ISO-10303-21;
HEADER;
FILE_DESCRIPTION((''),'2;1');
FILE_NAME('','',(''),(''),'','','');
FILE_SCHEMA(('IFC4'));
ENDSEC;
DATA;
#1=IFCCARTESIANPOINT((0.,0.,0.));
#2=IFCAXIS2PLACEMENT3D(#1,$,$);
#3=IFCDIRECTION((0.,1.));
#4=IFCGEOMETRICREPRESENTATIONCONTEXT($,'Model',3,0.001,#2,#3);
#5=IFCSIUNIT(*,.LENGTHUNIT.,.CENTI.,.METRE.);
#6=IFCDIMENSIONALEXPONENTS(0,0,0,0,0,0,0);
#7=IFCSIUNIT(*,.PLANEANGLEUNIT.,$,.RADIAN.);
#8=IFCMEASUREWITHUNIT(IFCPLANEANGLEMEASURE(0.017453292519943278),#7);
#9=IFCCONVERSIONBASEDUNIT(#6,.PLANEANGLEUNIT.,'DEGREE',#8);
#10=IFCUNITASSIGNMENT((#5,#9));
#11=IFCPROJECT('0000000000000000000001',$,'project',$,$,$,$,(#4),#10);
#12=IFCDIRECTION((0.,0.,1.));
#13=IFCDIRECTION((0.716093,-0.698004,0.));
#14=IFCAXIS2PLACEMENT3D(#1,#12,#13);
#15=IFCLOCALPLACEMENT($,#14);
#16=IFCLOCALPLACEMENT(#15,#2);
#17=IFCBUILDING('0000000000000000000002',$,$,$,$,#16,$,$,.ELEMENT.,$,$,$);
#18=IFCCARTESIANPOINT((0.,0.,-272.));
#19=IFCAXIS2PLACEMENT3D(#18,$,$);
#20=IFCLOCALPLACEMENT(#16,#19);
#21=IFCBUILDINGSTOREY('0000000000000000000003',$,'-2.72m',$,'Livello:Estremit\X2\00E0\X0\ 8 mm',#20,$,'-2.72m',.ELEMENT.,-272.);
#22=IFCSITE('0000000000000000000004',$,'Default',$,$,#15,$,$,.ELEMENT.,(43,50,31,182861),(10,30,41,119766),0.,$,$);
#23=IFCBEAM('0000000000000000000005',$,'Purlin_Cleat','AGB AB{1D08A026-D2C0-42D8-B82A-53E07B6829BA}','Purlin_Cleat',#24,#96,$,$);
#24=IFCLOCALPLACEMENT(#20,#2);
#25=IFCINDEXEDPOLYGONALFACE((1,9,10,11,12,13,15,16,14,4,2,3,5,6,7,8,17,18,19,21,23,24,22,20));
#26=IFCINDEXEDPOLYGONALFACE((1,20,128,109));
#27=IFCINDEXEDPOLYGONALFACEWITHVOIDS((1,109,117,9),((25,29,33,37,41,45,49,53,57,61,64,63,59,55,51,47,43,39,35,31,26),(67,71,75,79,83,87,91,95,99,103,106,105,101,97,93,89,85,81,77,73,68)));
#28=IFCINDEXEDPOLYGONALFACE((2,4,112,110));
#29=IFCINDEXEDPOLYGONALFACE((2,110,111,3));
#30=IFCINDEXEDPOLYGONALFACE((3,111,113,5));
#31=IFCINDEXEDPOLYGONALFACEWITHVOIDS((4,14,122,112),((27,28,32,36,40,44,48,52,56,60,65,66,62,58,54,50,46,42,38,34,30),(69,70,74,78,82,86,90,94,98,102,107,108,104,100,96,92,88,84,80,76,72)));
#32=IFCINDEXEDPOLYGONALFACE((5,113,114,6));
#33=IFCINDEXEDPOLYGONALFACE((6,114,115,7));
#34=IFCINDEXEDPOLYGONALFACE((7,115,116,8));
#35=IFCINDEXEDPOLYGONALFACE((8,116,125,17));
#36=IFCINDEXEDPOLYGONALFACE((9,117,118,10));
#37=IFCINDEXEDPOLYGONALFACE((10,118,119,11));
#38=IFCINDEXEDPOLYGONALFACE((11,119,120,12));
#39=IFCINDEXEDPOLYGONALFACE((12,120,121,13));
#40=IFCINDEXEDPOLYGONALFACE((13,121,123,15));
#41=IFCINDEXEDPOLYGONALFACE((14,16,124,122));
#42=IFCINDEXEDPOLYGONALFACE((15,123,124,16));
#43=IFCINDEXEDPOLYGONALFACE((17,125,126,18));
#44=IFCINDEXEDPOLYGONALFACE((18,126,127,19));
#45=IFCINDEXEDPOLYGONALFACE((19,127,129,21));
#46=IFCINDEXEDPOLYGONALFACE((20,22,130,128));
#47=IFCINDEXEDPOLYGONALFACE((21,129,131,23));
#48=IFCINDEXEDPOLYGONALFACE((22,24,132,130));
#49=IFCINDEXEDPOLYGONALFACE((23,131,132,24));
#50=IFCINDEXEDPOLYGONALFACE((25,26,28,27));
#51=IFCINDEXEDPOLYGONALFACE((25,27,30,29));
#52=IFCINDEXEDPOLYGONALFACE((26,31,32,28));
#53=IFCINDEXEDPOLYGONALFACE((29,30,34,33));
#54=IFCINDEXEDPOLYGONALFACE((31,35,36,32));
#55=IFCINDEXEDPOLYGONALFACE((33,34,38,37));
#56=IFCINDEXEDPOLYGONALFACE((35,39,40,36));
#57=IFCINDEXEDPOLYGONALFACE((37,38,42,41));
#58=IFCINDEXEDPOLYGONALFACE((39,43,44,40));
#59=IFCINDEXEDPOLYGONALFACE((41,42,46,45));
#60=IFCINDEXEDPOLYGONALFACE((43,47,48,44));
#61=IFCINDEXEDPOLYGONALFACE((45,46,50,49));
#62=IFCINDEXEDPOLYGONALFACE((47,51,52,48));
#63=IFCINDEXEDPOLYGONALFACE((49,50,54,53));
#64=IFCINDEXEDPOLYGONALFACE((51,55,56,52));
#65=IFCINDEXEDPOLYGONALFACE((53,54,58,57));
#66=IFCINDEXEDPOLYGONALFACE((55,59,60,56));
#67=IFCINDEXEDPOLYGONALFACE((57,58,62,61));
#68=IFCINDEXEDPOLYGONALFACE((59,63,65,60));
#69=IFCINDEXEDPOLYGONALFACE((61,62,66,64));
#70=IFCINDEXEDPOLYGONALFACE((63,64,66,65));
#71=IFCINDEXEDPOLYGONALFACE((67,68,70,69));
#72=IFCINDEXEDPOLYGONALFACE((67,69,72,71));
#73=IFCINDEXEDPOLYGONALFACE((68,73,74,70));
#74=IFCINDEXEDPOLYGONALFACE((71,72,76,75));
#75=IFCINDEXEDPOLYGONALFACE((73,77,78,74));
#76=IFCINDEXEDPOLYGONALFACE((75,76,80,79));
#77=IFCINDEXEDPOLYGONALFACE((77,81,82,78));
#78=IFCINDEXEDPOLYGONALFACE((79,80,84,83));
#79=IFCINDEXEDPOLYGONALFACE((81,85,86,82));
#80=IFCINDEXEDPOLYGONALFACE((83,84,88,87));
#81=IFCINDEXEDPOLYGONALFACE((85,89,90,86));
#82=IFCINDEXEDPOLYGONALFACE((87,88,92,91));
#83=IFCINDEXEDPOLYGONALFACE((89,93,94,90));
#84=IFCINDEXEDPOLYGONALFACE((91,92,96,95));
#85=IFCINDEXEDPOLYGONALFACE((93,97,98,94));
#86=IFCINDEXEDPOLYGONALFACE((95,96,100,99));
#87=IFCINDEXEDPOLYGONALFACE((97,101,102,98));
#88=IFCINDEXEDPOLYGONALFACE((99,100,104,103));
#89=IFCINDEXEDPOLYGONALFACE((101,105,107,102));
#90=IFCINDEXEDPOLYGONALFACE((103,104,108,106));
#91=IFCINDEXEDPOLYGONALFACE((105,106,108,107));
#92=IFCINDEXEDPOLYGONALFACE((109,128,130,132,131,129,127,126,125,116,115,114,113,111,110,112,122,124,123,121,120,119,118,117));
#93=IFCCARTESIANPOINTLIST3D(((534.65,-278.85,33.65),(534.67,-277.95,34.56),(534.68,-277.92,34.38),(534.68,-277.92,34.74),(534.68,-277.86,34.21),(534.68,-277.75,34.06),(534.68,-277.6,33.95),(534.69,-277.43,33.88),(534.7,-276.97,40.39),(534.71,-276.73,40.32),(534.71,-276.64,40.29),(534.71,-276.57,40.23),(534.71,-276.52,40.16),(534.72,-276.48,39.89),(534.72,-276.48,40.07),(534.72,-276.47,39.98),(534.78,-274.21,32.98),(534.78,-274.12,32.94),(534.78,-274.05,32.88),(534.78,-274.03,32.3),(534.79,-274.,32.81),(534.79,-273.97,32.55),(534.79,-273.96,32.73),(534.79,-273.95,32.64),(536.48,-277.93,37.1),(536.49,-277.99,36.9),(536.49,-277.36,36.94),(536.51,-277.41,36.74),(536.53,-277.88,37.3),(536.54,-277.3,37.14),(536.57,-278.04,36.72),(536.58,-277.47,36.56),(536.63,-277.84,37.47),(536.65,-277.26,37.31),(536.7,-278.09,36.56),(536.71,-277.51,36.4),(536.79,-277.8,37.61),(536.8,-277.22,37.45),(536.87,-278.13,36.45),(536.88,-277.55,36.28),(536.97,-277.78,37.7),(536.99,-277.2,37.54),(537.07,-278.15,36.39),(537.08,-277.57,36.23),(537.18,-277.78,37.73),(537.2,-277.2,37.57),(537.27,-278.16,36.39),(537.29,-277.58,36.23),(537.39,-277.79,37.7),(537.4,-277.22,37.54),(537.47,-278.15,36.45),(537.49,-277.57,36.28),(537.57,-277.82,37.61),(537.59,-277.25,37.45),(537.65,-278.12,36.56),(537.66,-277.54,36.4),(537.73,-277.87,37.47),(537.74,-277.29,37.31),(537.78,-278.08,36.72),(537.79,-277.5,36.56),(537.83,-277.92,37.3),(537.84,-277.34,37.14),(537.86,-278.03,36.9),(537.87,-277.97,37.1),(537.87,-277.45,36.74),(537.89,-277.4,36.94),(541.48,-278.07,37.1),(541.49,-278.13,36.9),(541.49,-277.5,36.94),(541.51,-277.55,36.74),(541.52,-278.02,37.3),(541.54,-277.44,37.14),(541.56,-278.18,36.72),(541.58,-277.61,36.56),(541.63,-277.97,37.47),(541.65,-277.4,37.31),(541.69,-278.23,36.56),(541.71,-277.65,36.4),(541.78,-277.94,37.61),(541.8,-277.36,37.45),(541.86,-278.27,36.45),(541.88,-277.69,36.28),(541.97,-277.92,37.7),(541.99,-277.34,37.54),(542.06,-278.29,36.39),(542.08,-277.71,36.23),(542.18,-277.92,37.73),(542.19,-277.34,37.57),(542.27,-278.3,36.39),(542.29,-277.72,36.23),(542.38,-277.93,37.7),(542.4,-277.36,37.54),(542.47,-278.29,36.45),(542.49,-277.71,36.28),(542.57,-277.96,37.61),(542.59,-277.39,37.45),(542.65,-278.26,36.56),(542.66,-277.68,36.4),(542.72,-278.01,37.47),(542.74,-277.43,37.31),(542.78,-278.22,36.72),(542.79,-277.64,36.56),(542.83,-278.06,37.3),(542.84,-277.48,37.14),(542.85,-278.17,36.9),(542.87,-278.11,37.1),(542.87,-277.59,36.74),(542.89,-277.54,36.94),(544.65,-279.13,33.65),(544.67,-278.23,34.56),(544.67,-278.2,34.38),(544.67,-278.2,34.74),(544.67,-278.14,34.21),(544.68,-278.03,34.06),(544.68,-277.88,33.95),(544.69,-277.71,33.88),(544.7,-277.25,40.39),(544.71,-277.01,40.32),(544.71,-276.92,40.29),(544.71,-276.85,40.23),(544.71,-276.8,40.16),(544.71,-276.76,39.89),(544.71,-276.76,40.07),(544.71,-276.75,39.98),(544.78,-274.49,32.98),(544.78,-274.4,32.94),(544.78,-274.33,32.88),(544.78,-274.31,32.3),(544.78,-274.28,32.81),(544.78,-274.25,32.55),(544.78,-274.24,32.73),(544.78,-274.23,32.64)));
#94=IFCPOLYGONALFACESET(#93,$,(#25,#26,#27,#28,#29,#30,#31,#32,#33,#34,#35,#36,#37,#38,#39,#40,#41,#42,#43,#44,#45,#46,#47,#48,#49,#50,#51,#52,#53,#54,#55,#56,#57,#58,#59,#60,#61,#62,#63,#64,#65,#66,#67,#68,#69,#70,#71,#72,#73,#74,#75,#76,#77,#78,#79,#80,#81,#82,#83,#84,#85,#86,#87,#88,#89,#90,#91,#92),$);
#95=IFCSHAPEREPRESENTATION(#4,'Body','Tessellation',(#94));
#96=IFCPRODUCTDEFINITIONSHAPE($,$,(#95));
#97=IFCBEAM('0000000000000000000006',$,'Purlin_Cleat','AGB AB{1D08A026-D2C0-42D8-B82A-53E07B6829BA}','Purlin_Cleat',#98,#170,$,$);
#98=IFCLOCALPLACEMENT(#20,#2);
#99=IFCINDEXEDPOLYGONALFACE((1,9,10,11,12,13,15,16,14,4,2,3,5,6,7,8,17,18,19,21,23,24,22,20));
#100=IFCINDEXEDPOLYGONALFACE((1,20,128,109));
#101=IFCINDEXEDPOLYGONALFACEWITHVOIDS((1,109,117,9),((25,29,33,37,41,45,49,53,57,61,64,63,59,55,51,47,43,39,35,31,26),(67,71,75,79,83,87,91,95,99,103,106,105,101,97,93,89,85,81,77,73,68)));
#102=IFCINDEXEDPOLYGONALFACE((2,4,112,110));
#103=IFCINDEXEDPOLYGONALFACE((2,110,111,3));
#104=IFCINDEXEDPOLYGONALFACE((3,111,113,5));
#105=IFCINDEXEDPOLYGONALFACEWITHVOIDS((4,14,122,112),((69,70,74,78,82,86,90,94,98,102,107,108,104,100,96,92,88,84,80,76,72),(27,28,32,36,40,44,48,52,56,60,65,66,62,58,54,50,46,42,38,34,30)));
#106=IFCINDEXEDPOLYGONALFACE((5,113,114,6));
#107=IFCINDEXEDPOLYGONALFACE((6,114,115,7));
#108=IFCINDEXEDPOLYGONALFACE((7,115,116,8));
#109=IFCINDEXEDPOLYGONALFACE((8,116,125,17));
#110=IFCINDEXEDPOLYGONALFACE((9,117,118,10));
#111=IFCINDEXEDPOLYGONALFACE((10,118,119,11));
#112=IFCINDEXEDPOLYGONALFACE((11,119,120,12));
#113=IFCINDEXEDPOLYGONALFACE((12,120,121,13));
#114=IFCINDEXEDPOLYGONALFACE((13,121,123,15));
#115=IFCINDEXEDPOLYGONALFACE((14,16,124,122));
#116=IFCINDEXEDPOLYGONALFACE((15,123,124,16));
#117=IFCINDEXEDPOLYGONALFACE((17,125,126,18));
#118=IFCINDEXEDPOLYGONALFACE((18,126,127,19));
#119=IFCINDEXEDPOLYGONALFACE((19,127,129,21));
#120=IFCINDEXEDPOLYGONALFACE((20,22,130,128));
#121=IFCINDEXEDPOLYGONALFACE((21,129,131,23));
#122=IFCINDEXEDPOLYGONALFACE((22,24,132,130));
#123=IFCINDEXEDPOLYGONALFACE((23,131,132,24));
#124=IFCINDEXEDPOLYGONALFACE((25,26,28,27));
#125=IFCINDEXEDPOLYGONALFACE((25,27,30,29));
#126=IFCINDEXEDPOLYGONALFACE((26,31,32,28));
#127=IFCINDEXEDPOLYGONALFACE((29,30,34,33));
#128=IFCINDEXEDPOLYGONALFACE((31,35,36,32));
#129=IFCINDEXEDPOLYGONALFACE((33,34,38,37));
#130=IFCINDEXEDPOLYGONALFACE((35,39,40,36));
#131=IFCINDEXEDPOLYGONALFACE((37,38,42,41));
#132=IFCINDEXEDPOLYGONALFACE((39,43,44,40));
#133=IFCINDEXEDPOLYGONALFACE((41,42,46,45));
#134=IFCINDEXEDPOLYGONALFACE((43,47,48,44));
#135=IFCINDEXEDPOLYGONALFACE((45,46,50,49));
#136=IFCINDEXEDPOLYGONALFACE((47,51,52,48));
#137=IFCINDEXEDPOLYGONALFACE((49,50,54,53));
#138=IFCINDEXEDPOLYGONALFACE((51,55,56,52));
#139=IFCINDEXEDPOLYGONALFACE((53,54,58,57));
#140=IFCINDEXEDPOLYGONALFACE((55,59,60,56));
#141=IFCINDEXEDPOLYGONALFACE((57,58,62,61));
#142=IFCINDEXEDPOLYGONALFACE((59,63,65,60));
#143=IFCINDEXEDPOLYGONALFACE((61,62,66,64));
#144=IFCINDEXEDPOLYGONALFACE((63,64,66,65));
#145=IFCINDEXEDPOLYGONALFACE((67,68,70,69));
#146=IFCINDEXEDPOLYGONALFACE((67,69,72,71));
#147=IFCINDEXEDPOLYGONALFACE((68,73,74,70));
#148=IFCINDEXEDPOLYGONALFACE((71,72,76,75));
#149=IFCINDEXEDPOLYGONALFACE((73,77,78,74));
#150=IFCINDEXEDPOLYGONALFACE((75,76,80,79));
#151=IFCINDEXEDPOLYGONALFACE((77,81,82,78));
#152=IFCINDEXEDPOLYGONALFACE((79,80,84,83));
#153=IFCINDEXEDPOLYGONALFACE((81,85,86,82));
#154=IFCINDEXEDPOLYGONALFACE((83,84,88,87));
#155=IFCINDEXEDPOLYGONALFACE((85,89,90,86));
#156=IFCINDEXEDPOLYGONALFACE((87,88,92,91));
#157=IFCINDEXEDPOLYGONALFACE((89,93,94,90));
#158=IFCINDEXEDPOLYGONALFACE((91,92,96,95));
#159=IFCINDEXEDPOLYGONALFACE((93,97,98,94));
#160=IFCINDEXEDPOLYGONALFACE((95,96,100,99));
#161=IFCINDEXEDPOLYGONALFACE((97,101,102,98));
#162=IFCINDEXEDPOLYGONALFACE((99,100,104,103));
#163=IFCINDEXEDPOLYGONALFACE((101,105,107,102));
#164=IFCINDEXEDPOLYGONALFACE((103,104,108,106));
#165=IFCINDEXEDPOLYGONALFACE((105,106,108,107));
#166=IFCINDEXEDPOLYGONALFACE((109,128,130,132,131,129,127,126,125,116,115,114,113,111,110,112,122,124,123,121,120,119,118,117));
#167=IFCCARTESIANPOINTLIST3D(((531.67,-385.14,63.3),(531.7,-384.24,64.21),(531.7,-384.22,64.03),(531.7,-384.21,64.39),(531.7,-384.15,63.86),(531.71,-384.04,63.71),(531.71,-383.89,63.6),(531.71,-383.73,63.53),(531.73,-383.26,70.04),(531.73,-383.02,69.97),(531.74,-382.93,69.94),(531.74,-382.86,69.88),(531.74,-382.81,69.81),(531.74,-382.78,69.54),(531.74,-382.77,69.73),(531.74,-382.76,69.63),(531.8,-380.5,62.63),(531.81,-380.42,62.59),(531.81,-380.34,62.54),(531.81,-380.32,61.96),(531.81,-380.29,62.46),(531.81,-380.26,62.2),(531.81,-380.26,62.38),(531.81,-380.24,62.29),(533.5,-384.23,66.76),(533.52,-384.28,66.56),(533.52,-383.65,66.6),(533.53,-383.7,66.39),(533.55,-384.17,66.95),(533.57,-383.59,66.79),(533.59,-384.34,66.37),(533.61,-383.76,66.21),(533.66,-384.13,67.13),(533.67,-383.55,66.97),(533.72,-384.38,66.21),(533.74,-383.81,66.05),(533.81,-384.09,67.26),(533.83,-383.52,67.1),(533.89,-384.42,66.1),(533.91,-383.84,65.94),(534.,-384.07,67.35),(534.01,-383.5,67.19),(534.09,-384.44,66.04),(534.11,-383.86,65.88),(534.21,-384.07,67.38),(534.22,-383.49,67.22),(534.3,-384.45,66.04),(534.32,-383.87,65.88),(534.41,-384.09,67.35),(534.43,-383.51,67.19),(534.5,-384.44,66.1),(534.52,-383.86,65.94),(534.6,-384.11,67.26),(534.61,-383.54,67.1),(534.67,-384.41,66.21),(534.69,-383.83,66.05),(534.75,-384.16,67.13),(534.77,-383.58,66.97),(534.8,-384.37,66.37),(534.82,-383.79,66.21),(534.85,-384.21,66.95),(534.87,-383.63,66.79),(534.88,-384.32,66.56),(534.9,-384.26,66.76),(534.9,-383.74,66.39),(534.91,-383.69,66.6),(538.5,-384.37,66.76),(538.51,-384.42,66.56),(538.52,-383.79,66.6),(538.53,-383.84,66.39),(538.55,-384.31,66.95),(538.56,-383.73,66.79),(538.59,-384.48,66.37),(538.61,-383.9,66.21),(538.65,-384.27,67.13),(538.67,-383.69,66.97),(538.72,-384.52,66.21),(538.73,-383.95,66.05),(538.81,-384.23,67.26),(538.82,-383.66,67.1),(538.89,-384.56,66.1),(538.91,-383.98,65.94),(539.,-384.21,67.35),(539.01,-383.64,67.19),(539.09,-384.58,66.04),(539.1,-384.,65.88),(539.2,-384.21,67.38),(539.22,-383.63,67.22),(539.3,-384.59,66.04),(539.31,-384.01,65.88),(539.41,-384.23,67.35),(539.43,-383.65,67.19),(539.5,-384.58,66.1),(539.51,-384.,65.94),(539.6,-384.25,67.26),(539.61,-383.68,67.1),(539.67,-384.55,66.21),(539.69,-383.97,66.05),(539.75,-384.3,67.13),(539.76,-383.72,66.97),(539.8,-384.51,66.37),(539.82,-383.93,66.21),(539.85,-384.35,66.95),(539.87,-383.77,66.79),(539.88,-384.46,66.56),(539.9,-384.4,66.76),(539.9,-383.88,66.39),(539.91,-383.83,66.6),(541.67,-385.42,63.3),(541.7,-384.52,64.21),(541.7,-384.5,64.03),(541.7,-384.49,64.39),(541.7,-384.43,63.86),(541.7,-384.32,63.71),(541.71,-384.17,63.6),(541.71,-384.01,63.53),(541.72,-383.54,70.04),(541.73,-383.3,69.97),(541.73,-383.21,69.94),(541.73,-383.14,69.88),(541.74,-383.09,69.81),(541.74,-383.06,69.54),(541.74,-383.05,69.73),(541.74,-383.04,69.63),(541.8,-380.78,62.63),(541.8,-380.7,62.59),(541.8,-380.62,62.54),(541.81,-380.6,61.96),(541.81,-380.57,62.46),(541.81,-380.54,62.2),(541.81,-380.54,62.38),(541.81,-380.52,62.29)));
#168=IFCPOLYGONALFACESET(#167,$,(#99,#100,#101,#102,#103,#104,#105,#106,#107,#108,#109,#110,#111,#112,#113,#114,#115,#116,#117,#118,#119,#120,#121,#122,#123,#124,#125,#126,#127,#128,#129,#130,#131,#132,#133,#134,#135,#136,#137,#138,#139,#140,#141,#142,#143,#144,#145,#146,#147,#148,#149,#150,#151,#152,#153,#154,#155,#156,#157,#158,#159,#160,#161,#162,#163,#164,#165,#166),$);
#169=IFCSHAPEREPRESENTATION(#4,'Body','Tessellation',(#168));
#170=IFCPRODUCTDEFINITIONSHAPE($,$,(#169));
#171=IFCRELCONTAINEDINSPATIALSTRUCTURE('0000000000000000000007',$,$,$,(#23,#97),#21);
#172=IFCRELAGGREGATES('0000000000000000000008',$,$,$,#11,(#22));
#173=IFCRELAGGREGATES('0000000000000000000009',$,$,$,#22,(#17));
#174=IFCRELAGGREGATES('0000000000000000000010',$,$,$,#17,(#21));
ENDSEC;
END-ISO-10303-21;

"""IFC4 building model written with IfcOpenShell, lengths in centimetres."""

from ifc_helpers import new_model, entity, si_unit, converted_unit, direction, frame, frame_2d, origin, place, context, project, spatial, circle, l_section, extrude, element, save


model = new_model("IFC4")

# Units and contexts
model_context = context("Model", 3, precision=0.001, world=origin(), true_north=direction((0.0, 1.0)))
ifc_project = project(units=[si_unit("LENGTHUNIT", "METRE", prefix="CENTI"), converted_unit("PLANEANGLEUNIT", "DEGREE", entity("IfcPlaneAngleMeasure", 0.017453292519943278), si_unit("PLANEANGLEUNIT", "RADIAN"), dimensions=[0, 0, 0, 0, 0, 0, 0])], contexts=[model_context])

# Site, building, storey
site_placement = place(None, frame((0.0, 0.0, 0.0), z_axis=(0.0, 0.0, 1.0), x_axis=(0.716093, -0.698004, 0.0)))
site = spatial("IfcSite", under=ifc_project, at=site_placement, Name="Default", CompositionType="ELEMENT", RefLatitude=(43, 50, 31, 182861), RefLongitude=(10, 30, 41, 119766), RefElevation=0.0)
building_placement = place(site_placement, origin())
building = spatial("IfcBuilding", under=site, at=building_placement, CompositionType="ELEMENT")
storey_placement = place(building_placement, frame((0.0, 0.0, -272.0)))
storey = spatial("IfcBuildingStorey", under=building, at=storey_placement, Name="-2.72m", ObjectType="Livello:Estremità 8 mm", LongName="-2.72m", CompositionType="ELEMENT", Elevation=-272.0)

# Beams, openings
beam_1_placement = place(storey_placement, frame((544.7, -277.34, 35.48), z_axis=(-0.999608, 0.02798, 0.0), x_axis=(0.007515, 0.268478, 0.963256)))
beam_1 = element("IfcBeam", 1, at=beam_1_placement, inside=storey, Name="Purlin_Cleat", Description="AGB AB{1D08A026-D2C0-42D8-B82A-53E07B6829BA}", ObjectType="Purlin_Cleat", context=model_context, shape_type="SweptSolid", body=[
    extrude(l_section(Depth=5.0, Width=7.0, Thickness=0.6, FilletRadius=0.7, EdgeRadius=0.35, at=frame_2d((1.25, 1.27))), origin(), (0.0, 0.0, 1.0), 10.0),
])
opening_1_placement = place(beam_1_placement, frame((1.29, -1.3, 6.8), z_axis=(0.0, -1.0, 0.0), x_axis=(1.0, 0.0, 0.0)))
element("IfcOpeningElement", 2, at=opening_1_placement, cuts=beam_1, ObjectType="Opening", context=model_context, shape_type="SweptSolid", body=[
    extrude(circle(Radius=0.7, at=frame_2d((0.0, 0.7), x_axis=(1.0, 0.0))), origin(), (0.0, 0.0, -1.0), 0.7),
])
opening_2_placement = place(beam_1_placement, frame((1.29, -1.3, 1.8), z_axis=(0.0, -1.0, 0.0), x_axis=(1.0, 0.0, 0.0)))
element("IfcOpeningElement", 3, at=opening_2_placement, cuts=beam_1, ObjectType="Opening", context=model_context, shape_type="SweptSolid", body=[
    extrude(circle(Radius=0.7, at=frame_2d((0.0, 0.7), x_axis=(1.0, 0.0))), origin(), (0.0, 0.0, -1.0), 0.7),
])
beam_2_placement = place(storey_placement, frame((541.72, -383.63, 65.14), z_axis=(-0.999608, 0.02798, 0.0), x_axis=(0.007515, 0.268478, 0.963256)))
beam_2 = element("IfcBeam", 4, at=beam_2_placement, inside=storey, Name="Purlin_Cleat", Description="AGB AB{1D08A026-D2C0-42D8-B82A-53E07B6829BA}", ObjectType="Purlin_Cleat", context=model_context, shape_type="SweptSolid", body=[
    extrude(l_section(Depth=5.0, Width=7.0, Thickness=0.6, FilletRadius=0.7, EdgeRadius=0.35, at=frame_2d((1.25, 1.27))), origin(), (0.0, 0.0, 1.0), 10.0),
])
opening_3_placement = place(beam_2_placement, frame((1.29, -1.3, 6.8), z_axis=(0.0, -1.0, 0.0), x_axis=(1.0, 0.0, 0.0)))
element("IfcOpeningElement", 5, at=opening_3_placement, cuts=beam_2, ObjectType="Opening", context=model_context, shape_type="SweptSolid", body=[
    extrude(circle(Radius=0.7, at=frame_2d((0.0, 0.7), x_axis=(1.0, 0.0))), origin(), (0.0, 0.0, -1.0), 0.7),
])
opening_4_placement = place(beam_2_placement, frame((1.29, -1.3, 1.8), z_axis=(0.0, -1.0, 0.0), x_axis=(1.0, 0.0, 0.0)))
element("IfcOpeningElement", 6, at=opening_4_placement, cuts=beam_2, ObjectType="Opening", context=model_context, shape_type="SweptSolid", body=[
    extrude(circle(Radius=0.7, at=frame_2d((0.0, 0.7), x_axis=(1.0, 0.0))), origin(), (0.0, 0.0, -1.0), 0.7),
])

save(model, "model.ifc")
